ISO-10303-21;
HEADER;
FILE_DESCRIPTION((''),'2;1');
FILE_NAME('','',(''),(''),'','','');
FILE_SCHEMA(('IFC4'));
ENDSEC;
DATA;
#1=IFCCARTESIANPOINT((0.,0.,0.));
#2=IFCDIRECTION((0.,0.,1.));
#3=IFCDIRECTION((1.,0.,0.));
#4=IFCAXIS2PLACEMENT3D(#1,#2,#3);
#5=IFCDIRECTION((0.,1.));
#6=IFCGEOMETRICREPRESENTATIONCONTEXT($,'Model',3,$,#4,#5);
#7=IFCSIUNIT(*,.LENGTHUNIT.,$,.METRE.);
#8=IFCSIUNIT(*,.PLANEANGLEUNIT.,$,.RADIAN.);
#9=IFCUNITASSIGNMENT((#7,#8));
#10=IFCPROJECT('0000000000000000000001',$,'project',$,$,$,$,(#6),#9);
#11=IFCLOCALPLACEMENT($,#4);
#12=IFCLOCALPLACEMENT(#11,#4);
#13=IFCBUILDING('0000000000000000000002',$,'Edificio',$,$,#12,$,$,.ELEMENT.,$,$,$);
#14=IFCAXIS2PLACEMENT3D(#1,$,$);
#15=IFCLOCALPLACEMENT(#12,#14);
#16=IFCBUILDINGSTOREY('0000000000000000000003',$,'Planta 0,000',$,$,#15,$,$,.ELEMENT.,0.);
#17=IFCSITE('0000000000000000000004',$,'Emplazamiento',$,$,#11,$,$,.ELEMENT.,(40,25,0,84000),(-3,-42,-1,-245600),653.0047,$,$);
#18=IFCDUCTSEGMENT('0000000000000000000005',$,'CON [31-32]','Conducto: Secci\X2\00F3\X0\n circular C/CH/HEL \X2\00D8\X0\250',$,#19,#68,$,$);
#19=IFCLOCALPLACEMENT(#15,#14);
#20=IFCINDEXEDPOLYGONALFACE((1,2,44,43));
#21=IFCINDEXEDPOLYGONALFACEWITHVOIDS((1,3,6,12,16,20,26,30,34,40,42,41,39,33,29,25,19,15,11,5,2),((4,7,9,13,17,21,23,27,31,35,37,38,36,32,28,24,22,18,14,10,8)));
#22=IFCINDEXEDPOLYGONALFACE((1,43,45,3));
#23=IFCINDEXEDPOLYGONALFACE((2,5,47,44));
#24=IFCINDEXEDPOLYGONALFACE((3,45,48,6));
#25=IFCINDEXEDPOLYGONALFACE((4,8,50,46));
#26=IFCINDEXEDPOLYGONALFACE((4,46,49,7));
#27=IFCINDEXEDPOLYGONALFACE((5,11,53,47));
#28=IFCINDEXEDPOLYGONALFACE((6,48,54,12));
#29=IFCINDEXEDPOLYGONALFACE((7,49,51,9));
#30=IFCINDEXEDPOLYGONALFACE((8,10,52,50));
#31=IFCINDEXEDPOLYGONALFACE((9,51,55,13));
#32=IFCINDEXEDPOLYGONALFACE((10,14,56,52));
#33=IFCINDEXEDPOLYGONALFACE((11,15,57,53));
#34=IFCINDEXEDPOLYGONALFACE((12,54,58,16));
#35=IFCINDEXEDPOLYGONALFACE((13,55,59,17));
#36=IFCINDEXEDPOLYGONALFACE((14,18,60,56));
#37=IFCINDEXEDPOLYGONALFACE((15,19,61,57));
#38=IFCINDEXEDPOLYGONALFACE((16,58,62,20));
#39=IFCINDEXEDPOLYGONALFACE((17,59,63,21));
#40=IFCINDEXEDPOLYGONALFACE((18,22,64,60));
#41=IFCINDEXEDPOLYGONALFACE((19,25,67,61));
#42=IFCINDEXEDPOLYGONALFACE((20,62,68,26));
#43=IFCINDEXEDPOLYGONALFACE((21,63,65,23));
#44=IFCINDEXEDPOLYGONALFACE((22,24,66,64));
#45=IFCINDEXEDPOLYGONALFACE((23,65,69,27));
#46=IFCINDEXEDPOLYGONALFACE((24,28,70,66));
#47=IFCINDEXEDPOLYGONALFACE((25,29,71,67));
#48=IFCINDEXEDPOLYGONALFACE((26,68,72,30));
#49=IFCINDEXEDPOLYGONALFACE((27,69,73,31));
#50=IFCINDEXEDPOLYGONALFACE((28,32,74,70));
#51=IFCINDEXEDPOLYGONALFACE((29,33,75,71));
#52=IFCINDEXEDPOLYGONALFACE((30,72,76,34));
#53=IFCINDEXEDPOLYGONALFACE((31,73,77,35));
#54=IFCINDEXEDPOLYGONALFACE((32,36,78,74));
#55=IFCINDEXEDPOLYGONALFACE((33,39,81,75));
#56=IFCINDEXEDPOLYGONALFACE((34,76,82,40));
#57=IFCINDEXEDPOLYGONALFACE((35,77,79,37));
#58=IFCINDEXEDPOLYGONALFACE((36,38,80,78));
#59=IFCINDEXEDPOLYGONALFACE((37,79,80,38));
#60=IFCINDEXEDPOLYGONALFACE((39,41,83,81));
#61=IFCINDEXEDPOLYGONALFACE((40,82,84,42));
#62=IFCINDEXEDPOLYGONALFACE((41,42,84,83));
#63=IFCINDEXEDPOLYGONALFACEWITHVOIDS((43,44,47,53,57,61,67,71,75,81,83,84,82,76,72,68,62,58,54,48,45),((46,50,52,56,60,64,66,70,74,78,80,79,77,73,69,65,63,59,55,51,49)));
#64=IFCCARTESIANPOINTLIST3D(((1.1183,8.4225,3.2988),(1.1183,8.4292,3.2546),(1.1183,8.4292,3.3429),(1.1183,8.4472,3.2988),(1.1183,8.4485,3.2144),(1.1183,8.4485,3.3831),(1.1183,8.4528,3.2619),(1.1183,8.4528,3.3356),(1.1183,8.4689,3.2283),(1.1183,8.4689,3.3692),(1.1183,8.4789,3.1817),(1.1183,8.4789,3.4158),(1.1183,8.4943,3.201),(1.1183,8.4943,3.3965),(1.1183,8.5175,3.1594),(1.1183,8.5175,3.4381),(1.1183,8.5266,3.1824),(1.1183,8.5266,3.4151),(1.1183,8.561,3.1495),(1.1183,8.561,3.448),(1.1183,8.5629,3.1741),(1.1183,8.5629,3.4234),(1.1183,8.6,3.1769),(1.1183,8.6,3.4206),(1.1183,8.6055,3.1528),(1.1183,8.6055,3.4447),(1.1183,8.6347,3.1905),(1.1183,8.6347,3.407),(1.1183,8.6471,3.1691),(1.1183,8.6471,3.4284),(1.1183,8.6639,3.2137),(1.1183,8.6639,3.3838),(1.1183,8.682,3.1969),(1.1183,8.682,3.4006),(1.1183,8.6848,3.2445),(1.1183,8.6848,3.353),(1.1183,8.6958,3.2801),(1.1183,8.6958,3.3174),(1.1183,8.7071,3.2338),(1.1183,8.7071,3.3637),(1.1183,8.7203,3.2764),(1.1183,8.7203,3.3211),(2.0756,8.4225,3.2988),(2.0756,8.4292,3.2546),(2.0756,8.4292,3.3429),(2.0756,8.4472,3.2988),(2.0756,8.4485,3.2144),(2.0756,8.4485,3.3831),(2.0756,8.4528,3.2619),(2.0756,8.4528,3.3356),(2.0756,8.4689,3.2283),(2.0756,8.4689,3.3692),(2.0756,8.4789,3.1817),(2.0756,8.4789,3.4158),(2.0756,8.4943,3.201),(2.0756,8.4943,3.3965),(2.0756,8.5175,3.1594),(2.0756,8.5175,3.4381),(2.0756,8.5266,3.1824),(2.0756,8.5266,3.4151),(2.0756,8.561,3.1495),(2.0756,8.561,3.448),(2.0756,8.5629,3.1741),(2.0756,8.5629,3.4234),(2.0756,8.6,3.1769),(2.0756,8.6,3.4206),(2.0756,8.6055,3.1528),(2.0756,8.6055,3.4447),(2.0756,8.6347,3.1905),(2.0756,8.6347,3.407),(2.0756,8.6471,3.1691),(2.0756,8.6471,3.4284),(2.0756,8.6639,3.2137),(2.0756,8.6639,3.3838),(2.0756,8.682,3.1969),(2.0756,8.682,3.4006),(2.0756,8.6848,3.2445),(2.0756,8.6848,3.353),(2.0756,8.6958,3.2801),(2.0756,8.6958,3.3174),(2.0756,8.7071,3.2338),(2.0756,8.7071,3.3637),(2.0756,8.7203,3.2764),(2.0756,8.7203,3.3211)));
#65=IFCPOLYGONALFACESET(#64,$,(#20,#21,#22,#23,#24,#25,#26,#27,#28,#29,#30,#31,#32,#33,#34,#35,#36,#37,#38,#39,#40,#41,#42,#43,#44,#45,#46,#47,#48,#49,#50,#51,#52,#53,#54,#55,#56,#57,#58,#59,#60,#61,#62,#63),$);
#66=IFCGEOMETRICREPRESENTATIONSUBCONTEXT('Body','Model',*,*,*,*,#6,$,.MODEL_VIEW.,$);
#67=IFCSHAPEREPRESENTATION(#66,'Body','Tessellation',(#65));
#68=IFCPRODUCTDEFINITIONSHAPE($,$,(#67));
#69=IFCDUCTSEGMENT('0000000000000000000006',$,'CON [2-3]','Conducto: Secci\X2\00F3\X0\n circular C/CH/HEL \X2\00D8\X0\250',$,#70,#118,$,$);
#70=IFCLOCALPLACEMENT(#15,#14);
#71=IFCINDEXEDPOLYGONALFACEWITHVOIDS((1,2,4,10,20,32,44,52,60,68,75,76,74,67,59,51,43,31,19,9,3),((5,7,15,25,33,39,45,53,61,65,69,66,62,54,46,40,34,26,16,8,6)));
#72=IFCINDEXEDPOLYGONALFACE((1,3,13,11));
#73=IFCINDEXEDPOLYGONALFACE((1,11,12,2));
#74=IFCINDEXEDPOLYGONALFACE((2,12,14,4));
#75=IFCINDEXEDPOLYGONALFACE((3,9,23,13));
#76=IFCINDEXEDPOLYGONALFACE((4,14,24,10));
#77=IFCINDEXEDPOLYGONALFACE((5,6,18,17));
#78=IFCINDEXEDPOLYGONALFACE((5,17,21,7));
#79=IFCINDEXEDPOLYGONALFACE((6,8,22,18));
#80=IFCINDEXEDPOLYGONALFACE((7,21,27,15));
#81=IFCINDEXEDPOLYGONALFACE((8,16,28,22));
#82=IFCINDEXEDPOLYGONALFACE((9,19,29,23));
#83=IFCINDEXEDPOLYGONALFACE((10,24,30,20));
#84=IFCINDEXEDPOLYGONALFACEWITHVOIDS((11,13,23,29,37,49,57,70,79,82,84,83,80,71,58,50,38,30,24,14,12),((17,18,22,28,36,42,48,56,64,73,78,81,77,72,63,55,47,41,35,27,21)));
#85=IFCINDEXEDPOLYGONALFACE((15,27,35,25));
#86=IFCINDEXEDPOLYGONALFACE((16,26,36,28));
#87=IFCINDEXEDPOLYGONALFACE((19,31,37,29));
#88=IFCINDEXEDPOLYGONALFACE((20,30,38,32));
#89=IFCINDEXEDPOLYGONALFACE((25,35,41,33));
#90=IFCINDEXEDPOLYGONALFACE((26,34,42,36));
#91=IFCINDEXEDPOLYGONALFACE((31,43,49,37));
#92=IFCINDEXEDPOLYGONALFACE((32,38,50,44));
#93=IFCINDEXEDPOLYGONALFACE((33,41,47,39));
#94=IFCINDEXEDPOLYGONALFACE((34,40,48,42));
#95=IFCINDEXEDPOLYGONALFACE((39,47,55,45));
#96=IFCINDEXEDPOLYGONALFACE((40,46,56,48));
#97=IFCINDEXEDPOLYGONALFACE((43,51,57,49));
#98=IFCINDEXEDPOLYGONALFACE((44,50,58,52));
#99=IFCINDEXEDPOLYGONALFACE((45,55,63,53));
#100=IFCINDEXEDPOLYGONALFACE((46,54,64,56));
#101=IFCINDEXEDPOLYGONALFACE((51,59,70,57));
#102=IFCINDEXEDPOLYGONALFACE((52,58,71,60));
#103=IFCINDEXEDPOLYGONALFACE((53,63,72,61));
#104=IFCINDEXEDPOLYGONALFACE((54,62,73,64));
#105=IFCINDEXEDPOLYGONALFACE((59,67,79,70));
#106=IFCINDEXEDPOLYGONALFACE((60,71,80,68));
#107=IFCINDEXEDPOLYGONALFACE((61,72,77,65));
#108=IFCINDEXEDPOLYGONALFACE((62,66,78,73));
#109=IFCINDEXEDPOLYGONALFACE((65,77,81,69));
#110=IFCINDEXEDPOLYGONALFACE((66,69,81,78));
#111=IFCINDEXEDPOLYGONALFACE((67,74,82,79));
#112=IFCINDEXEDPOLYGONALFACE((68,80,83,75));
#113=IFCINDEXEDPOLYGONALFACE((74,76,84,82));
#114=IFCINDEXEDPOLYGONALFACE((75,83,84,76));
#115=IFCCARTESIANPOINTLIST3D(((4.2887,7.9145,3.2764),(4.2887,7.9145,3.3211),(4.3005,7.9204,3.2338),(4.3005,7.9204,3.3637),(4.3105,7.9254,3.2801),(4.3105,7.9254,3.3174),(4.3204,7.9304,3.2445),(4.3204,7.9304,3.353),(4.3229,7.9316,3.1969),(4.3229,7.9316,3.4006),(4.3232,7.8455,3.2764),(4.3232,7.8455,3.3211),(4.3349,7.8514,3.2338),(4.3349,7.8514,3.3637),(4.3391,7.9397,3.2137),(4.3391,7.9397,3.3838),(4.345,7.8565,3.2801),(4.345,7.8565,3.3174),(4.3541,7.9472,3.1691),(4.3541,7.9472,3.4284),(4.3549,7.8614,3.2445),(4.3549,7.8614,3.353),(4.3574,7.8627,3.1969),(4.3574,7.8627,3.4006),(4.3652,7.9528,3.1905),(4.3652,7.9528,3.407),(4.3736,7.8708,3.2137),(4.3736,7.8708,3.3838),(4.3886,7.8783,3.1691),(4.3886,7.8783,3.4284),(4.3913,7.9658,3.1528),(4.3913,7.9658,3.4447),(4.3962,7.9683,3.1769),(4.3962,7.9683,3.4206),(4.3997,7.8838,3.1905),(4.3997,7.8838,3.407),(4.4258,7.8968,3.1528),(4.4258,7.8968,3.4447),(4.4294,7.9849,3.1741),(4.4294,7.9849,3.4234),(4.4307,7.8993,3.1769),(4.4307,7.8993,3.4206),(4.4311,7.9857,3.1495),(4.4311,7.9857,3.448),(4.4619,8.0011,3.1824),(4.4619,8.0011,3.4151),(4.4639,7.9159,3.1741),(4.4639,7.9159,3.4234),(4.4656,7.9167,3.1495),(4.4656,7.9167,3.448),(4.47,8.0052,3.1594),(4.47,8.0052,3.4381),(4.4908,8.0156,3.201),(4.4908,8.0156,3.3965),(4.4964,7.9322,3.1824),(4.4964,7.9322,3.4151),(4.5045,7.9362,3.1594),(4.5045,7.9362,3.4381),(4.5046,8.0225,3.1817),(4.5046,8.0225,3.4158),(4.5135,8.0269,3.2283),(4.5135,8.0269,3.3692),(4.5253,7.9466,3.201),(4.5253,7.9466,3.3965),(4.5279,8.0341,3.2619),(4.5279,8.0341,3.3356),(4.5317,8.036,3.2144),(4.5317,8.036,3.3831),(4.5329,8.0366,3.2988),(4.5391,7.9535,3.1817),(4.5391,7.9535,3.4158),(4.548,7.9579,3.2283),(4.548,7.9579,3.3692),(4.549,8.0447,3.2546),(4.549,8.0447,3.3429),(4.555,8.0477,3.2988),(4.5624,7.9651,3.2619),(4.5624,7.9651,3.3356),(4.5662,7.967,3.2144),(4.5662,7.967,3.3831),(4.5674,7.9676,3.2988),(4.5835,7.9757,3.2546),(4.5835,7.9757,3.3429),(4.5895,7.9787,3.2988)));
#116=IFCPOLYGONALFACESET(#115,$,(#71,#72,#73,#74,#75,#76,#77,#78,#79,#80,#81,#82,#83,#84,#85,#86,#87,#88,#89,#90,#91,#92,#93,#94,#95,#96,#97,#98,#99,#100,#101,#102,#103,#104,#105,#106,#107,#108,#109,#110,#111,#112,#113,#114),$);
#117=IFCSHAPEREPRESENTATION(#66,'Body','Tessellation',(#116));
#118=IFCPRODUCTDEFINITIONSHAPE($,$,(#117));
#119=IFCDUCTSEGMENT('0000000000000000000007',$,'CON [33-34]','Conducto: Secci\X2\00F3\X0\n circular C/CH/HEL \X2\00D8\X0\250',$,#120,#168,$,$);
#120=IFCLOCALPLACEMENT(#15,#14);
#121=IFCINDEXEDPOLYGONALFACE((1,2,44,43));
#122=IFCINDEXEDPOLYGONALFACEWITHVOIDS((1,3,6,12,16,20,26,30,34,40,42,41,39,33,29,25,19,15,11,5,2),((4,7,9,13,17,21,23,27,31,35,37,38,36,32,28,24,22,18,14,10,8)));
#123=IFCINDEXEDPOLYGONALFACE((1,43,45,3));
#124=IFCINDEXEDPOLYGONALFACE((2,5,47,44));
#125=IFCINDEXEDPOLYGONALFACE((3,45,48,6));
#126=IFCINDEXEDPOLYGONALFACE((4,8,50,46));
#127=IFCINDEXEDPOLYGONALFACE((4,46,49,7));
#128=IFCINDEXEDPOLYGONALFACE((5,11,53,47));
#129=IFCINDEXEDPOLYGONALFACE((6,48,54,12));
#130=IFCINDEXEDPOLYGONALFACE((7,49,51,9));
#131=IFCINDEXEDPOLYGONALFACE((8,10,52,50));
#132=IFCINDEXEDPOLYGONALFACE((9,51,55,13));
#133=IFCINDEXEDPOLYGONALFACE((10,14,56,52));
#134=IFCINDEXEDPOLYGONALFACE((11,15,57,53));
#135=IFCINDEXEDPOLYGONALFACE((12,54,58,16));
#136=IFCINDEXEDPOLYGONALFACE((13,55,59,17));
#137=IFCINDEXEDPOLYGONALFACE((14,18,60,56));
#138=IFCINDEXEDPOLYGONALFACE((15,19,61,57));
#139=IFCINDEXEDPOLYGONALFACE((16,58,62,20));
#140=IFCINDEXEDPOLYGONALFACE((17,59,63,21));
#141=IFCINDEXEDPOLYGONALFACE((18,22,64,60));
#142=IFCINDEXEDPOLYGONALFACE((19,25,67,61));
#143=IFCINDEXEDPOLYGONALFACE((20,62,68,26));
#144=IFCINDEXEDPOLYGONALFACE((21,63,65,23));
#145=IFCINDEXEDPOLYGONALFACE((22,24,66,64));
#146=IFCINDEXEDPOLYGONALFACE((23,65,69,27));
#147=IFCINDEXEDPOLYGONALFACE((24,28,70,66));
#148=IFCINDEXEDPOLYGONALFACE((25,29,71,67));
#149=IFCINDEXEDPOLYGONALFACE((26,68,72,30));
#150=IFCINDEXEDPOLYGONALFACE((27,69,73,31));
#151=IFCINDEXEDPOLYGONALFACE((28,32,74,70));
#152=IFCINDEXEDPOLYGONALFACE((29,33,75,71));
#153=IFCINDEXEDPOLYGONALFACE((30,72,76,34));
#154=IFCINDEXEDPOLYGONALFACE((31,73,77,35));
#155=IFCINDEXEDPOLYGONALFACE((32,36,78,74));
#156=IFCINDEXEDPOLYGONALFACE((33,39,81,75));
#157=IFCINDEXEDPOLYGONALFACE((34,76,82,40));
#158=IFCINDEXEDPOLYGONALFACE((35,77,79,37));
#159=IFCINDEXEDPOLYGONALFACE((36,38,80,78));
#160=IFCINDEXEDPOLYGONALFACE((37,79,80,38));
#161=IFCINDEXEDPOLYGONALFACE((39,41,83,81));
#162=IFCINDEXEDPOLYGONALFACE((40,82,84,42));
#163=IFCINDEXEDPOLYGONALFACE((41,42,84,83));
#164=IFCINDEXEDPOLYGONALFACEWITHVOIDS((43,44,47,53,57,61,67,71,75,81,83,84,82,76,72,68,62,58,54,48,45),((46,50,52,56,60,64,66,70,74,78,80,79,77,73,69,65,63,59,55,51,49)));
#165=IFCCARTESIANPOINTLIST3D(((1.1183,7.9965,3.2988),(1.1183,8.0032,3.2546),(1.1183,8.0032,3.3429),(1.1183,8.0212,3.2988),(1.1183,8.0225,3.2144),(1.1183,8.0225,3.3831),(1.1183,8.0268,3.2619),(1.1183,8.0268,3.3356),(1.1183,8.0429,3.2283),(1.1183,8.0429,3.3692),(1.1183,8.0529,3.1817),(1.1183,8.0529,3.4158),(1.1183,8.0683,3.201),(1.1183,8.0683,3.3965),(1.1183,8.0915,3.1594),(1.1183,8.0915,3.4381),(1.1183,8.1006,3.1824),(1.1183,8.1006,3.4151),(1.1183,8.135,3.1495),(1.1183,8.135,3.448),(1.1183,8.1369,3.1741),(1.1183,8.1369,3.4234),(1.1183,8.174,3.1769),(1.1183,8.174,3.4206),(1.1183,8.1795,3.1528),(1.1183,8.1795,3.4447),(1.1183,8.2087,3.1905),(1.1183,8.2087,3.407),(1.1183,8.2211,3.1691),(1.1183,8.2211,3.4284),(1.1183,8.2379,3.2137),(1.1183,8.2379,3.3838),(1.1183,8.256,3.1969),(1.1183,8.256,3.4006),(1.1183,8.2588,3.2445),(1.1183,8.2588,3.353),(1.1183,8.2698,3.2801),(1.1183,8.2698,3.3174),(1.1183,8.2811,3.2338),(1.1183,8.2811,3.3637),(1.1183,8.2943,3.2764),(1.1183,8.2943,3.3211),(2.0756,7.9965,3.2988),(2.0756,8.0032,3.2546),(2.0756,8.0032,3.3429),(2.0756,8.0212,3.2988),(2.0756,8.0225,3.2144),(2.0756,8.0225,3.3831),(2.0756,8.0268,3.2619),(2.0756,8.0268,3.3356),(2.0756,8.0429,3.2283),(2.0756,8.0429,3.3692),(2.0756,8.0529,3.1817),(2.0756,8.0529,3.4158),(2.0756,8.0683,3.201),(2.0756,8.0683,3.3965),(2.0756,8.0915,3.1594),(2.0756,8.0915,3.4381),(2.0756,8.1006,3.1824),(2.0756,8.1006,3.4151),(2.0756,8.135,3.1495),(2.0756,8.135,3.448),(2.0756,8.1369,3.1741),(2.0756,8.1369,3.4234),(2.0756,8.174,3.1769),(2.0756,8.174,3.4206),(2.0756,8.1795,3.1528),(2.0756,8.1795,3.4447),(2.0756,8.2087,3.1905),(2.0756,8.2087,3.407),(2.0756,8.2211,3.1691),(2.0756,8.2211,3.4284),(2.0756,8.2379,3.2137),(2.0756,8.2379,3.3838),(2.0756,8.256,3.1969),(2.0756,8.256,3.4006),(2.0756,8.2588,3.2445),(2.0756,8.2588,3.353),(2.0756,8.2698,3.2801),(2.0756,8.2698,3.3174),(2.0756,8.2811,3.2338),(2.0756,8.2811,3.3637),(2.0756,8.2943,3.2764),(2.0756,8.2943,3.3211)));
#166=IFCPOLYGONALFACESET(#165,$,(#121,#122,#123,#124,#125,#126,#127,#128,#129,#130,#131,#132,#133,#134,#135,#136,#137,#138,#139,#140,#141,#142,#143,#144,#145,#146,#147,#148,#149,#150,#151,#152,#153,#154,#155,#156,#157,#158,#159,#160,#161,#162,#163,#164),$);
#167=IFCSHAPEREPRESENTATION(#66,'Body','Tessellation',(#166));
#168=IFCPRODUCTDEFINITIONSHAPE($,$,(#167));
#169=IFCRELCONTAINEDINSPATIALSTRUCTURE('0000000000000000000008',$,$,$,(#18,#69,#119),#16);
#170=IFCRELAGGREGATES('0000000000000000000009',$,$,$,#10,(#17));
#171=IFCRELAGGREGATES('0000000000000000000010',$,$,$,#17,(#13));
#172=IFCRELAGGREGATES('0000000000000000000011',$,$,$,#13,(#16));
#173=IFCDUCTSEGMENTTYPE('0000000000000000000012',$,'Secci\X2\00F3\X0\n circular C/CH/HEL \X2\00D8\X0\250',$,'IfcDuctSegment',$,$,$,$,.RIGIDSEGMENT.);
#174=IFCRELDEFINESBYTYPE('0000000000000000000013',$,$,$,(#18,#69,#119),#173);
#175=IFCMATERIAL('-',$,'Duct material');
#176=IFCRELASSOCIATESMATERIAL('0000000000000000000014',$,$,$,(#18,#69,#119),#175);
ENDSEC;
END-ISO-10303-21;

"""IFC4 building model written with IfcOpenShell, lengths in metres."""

from ifc_helpers import new_model, si_unit, direction, frame, origin, origin_with_axes, origin_2d_with_axis, place, context, subcontext, project, spatial, hollow_circle, extrude, material, type_object, element, save


model = new_model("IFC4")

# Units and contexts
model_context = context("Model", 3, world=origin_with_axes(), true_north=direction((0.0, 1.0)))
body_context = subcontext(model_context, "Body", "Model", "MODEL_VIEW")
ifc_project = project(units=[si_unit("LENGTHUNIT", "METRE"), si_unit("PLANEANGLEUNIT", "RADIAN")], contexts=[model_context])

# Site, building, storey
site_placement = place(None, origin_with_axes())
site = spatial("IfcSite", under=ifc_project, at=site_placement, Name="Emplazamiento", CompositionType="ELEMENT", RefLatitude=(40, 25, 0, 84000), RefLongitude=(-3, -42, -1, -245600), RefElevation=653.0047)
building_placement = place(site_placement, origin_with_axes())
building = spatial("IfcBuilding", under=site, at=building_placement, Name="Edificio", CompositionType="ELEMENT")
storey_placement = place(building_placement, origin())
storey = spatial("IfcBuildingStorey", under=building, at=storey_placement, Name="Planta 0,000", CompositionType="ELEMENT", Elevation=0.0)

# Shared definitions
ifc_material_1 = material(Name="-", Category="Duct material")

# Duct segments
duct_segment_type_1 = type_object("IfcDuctSegmentType", Name="Sección circular C/CH/HEL Ø250", ApplicableOccurrence="IfcDuctSegment", PredefinedType="RIGIDSEGMENT")
duct_segment_1_placement = place(storey_placement, origin_with_axes())
element("IfcDuctSegment", 1, at=duct_segment_1_placement, inside=storey, type_object=duct_segment_type_1, material=ifc_material_1, Name="CON [31-32]", Description="Conducto: Sección circular C/CH/HEL Ø250", context=body_context, shape_type="SweptSolid", body=[
    extrude(hollow_circle(Radius=0.1497, WallThickness=0.0247, at=origin_2d_with_axis()), frame((2.0756, 8.5722, 3.2988), z_axis=(-1.0, 0.0, 0.0), x_axis=(0.0, -1.0, 0.0)), (0.0, 0.0, 1.0), 0.9572),
])
duct_segment_2_placement = place(storey_placement, origin_with_axes())
element("IfcDuctSegment", 2, at=duct_segment_2_placement, inside=storey, type_object=duct_segment_type_1, material=ifc_material_1, Name="CON [2-3]", Description="Conducto: Sección circular C/CH/HEL Ø250", context=body_context, shape_type="SweptSolid", body=[
    extrude(hollow_circle(Radius=0.1497, WallThickness=0.0247, at=origin_2d_with_axis()), frame((4.4211, 7.9807, 3.2988), z_axis=(0.447214, -0.894427, 0.0), x_axis=(0.894427, 0.447214, 0.0)), (0.0, 0.0, 1.0), 0.0771),
])
duct_segment_3_placement = place(storey_placement, origin_with_axes())
element("IfcDuctSegment", 3, at=duct_segment_3_placement, inside=storey, type_object=duct_segment_type_1, material=ifc_material_1, Name="CON [33-34]", Description="Conducto: Sección circular C/CH/HEL Ø250", context=body_context, shape_type="SweptSolid", body=[
    extrude(hollow_circle(Radius=0.1497, WallThickness=0.0247, at=origin_2d_with_axis()), frame((2.0756, 8.1462, 3.2988), z_axis=(-1.0, 0.0, 0.0), x_axis=(0.0, -1.0, 0.0)), (0.0, 0.0, 1.0), 0.9572),
])

save(model, "model.ifc")
